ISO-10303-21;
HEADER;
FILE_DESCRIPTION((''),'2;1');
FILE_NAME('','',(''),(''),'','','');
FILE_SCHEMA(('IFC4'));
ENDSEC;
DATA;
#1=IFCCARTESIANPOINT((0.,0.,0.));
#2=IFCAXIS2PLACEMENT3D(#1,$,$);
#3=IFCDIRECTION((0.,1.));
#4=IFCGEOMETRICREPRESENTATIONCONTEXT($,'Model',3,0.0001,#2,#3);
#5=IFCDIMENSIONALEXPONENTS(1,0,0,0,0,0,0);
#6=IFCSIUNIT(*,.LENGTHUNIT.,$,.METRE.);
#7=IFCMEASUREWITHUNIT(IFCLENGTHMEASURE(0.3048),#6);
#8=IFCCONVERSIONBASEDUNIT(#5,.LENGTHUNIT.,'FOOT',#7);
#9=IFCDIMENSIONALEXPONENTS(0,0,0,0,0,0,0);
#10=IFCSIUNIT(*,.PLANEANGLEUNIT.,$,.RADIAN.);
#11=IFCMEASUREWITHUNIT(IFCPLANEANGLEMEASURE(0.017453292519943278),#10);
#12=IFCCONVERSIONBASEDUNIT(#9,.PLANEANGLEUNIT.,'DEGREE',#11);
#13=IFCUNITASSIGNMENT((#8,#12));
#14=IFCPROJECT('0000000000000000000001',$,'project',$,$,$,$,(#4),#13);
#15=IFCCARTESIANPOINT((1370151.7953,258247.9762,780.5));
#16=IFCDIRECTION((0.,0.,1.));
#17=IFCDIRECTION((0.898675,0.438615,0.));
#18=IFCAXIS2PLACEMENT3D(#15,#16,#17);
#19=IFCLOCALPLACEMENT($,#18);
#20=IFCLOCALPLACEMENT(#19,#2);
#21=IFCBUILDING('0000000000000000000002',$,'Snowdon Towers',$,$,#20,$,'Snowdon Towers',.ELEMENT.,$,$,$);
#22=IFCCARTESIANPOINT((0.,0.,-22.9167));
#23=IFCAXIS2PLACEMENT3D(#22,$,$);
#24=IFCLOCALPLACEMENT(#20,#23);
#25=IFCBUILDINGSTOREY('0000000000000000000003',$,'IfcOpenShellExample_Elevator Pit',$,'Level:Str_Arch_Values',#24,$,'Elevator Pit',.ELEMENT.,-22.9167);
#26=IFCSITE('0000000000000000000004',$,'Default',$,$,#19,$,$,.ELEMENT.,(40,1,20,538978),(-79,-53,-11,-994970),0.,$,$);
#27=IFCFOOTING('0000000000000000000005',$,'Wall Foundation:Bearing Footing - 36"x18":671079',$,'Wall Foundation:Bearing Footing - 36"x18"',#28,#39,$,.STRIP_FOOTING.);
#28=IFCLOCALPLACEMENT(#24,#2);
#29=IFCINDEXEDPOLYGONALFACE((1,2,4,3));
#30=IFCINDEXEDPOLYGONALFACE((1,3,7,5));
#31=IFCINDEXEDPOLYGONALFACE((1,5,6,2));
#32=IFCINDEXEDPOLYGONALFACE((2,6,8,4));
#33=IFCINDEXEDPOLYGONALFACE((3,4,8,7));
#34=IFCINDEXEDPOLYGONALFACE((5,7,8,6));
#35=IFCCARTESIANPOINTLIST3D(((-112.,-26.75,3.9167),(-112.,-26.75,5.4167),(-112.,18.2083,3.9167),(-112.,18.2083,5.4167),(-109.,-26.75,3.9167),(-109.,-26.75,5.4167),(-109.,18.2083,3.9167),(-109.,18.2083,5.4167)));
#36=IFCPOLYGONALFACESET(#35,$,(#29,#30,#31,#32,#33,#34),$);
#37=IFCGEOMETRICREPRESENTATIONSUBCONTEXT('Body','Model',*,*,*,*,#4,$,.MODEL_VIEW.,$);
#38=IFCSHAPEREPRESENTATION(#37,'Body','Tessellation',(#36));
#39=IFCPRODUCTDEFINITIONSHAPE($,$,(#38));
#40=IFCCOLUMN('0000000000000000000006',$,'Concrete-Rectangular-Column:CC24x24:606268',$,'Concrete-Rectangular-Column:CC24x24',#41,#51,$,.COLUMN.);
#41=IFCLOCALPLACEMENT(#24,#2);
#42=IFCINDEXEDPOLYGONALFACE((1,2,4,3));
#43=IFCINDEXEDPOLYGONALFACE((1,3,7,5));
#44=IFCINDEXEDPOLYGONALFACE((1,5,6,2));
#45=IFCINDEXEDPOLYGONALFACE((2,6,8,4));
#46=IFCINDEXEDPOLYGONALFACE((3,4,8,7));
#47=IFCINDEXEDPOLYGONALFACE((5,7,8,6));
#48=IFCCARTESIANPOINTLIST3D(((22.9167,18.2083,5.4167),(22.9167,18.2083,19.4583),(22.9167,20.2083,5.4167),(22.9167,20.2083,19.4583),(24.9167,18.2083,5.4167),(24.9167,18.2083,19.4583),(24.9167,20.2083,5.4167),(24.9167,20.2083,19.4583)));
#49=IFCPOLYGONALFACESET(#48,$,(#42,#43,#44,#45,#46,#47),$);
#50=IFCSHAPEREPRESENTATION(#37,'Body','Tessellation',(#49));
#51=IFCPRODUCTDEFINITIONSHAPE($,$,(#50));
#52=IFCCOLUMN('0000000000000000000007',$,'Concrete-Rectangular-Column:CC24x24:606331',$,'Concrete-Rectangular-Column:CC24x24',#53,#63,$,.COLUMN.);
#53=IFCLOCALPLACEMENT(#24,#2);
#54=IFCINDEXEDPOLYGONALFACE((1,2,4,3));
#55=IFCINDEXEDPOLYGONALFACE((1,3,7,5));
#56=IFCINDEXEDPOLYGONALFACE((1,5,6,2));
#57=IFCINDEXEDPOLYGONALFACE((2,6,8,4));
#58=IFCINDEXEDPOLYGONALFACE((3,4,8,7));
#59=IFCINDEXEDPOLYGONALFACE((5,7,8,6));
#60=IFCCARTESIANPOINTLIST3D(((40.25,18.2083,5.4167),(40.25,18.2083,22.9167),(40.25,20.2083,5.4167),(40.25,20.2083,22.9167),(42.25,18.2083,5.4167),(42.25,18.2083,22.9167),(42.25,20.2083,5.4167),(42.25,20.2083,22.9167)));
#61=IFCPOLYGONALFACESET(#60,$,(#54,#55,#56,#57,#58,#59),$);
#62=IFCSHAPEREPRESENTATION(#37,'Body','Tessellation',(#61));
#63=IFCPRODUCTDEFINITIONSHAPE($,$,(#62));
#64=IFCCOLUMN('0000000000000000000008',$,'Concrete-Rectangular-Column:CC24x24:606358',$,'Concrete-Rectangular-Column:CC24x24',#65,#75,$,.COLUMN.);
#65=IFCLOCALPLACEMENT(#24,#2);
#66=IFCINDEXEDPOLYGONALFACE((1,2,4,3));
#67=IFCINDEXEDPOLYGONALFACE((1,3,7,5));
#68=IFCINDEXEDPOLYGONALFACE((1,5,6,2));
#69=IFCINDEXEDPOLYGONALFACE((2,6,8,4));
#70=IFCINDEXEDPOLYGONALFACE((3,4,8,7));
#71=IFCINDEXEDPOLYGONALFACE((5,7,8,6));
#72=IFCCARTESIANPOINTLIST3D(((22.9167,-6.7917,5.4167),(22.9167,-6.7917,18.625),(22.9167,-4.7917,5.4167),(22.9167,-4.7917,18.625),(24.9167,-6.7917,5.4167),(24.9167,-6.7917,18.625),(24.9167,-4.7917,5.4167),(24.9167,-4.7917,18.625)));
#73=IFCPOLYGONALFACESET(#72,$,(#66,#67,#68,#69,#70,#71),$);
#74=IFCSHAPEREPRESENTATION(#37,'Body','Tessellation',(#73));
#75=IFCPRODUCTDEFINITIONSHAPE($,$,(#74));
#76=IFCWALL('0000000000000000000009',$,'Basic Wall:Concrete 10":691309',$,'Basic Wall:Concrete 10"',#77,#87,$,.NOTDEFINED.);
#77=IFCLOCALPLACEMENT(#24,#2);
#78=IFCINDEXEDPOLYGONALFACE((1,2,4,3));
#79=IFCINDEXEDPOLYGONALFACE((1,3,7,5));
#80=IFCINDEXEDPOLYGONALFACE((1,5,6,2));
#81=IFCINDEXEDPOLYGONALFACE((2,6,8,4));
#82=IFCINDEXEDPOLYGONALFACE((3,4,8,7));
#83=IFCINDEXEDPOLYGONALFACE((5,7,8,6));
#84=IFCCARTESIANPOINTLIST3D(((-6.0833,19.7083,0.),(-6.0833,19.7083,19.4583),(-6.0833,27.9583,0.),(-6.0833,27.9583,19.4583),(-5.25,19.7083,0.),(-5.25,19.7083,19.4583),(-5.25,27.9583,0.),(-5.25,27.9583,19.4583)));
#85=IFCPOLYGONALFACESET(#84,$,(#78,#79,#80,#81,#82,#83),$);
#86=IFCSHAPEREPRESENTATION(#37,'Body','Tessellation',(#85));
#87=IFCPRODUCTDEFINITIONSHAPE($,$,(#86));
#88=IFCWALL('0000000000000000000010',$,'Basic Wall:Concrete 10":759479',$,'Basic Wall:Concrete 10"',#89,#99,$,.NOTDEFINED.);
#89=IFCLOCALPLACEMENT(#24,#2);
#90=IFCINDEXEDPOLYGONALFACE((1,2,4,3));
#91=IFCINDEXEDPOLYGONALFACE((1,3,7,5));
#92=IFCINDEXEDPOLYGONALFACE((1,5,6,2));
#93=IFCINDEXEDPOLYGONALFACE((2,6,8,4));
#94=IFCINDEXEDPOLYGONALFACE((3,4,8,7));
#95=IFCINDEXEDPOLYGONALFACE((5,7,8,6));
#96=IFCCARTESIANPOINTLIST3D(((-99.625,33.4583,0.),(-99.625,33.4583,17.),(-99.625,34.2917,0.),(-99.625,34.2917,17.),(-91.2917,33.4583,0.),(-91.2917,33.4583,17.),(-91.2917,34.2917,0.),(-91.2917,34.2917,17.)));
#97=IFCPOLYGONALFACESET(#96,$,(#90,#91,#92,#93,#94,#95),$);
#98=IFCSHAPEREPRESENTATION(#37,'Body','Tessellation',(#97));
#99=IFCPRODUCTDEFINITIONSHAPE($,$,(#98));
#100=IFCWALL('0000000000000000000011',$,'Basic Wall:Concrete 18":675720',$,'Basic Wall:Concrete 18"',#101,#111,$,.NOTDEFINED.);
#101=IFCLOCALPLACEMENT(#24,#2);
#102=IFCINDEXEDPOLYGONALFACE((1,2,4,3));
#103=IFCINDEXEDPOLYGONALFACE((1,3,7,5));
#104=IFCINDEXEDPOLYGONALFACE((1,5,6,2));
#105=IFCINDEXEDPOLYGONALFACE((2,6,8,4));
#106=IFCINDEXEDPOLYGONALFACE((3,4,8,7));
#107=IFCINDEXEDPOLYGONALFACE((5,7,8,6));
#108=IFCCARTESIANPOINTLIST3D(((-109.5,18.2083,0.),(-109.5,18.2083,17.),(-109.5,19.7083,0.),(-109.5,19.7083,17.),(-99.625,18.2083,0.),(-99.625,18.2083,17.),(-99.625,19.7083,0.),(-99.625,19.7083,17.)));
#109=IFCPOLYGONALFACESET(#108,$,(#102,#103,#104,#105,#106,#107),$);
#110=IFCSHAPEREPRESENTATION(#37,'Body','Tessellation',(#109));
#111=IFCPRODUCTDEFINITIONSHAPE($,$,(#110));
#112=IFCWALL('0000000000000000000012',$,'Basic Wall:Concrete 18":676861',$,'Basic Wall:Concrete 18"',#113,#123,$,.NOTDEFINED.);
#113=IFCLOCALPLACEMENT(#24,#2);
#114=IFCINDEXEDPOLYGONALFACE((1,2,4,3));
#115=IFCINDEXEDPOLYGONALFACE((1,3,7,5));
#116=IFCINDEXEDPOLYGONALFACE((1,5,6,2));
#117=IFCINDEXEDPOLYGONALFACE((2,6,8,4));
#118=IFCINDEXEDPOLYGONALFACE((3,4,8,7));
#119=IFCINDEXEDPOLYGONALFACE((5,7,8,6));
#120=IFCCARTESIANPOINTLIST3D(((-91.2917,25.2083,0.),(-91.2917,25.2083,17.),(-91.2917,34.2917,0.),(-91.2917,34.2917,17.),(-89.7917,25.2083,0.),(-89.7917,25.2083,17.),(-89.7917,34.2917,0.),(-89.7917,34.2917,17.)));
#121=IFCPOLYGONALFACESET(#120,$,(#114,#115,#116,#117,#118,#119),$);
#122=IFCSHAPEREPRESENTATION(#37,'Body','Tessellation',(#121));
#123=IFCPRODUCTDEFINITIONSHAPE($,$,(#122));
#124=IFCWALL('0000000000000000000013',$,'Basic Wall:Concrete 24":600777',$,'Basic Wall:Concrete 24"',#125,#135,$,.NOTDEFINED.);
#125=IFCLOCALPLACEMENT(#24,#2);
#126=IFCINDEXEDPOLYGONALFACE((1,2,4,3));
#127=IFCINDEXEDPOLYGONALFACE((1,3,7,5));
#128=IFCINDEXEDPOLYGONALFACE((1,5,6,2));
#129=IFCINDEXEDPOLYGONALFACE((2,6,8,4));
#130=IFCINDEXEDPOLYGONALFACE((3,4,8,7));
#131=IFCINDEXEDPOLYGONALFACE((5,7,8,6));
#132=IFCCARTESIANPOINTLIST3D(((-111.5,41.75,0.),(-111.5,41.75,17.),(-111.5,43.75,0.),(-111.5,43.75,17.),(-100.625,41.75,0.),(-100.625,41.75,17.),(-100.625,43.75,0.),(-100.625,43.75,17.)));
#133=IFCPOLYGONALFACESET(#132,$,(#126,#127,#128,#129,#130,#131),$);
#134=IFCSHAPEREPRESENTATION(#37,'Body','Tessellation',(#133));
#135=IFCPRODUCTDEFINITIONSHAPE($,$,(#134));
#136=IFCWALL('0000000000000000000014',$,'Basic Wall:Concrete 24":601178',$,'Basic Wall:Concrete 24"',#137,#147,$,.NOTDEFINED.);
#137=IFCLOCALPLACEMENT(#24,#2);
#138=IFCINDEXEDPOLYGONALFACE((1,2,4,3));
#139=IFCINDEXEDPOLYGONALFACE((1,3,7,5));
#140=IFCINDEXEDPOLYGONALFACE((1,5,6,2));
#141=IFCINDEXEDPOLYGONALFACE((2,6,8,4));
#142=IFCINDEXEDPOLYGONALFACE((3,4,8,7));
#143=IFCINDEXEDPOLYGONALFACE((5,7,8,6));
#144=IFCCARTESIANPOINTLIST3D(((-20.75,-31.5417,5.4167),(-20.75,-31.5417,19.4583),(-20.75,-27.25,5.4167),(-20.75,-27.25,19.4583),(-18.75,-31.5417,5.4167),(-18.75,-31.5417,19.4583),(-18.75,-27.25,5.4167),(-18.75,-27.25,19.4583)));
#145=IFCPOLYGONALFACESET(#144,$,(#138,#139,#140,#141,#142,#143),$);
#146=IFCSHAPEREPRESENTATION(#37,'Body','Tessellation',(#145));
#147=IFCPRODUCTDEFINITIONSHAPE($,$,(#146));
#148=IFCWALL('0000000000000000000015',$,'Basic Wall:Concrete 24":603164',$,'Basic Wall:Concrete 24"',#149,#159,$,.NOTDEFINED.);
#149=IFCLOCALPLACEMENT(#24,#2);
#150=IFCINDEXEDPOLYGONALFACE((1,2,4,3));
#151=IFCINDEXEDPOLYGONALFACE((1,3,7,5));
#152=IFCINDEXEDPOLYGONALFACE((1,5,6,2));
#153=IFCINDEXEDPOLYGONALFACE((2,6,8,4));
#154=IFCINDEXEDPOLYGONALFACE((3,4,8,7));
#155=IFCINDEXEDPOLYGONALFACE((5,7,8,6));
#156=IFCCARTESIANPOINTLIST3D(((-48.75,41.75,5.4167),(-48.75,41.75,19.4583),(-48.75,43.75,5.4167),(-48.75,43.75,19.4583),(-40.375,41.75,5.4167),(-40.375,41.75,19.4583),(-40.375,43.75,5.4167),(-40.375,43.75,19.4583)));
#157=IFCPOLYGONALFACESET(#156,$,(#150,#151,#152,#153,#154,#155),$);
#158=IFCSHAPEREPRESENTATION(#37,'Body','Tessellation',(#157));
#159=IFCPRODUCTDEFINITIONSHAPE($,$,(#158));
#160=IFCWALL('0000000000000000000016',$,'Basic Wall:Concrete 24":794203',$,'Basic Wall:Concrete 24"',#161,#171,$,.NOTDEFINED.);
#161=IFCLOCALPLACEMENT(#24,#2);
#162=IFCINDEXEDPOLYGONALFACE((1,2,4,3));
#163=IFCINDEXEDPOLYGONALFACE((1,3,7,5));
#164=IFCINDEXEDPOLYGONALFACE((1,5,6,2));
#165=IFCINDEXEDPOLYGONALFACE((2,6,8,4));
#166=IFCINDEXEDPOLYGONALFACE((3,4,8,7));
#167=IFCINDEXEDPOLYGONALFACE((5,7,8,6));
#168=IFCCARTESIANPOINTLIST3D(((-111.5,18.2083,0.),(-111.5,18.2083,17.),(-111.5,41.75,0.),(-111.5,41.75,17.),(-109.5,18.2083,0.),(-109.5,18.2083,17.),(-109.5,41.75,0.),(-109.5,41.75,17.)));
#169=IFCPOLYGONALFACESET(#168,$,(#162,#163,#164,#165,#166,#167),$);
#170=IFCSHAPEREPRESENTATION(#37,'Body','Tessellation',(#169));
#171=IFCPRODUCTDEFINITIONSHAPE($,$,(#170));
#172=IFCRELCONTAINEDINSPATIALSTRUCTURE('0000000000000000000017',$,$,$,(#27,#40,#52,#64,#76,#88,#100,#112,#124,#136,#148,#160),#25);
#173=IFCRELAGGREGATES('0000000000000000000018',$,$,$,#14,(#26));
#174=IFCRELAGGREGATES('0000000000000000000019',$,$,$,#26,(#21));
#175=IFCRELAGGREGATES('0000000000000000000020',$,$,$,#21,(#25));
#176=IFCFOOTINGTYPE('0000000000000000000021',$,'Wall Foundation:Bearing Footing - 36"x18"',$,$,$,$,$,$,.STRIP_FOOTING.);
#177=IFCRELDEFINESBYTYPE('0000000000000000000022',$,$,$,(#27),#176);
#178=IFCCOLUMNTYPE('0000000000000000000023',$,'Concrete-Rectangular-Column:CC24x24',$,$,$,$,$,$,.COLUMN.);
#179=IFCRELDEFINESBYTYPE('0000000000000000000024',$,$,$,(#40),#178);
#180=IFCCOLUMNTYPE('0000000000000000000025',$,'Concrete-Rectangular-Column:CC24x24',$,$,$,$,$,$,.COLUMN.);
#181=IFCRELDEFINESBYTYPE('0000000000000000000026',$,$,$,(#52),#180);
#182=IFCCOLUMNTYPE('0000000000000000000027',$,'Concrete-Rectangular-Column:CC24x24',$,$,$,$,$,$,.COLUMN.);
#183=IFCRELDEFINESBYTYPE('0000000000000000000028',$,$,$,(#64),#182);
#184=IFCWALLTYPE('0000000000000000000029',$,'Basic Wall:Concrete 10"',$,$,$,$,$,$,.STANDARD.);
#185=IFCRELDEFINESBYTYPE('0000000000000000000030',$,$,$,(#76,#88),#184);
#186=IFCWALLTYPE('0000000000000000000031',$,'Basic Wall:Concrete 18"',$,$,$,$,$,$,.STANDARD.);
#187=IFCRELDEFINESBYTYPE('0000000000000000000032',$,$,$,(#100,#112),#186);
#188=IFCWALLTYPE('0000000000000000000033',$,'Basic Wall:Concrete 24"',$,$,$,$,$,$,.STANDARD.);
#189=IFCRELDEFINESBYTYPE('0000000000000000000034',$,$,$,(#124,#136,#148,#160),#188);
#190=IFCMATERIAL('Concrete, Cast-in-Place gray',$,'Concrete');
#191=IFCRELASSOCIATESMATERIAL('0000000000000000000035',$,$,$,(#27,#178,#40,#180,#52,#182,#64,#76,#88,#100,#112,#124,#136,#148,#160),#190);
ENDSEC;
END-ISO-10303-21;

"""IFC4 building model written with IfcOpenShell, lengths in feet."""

from ifc_helpers import new_model, entity, si_unit, converted_unit, direction, frame, origin, place, context, subcontext, project, spatial, indexed_curve, outline, extrude, source, transform, mapped, material, type_object, type_shapes, element, save


model = new_model("IFC4")

# Units and contexts
model_context = context("Model", 3, precision=0.0001, world=origin(), true_north=direction((0.0, 1.0)))
body_context = subcontext(model_context, "Body", "Model", "MODEL_VIEW")
ifc_project = project(units=[converted_unit("LENGTHUNIT", "FOOT", entity("IfcLengthMeasure", 0.3048), si_unit("LENGTHUNIT", "METRE"), dimensions=[1, 0, 0, 0, 0, 0, 0]), converted_unit("PLANEANGLEUNIT", "DEGREE", entity("IfcPlaneAngleMeasure", 0.017453292519943278), si_unit("PLANEANGLEUNIT", "RADIAN"), dimensions=[0, 0, 0, 0, 0, 0, 0])], contexts=[model_context])

# Site, building, storey
site_placement = place(None, frame((1370151.7953, 258247.9762, 780.5), z_axis=(0.0, 0.0, 1.0), x_axis=(0.898675, 0.438615, 0.0)))
site = spatial("IfcSite", under=ifc_project, at=site_placement, Name="Default", CompositionType="ELEMENT", RefLatitude=(40, 1, 20, 538978), RefLongitude=(-79, -53, -11, -994970), RefElevation=0.0)
building_placement = place(site_placement, origin())
building = spatial("IfcBuilding", under=site, at=building_placement, Name="Snowdon Towers", LongName="Snowdon Towers", CompositionType="ELEMENT")
storey_placement = place(building_placement, frame((0.0, 0.0, -22.9167)))
storey = spatial("IfcBuildingStorey", under=building, at=storey_placement, Name="IfcOpenShellExample_Elevator Pit", ObjectType="Level:Str_Arch_Values", LongName="Elevator Pit", CompositionType="ELEMENT", Elevation=-22.9167)

# Footing
ifc_material = material(Name="Concrete, Cast-in-Place gray", Category="Concrete")
footing_type = type_object("IfcFootingType", Name="Wall Foundation:Bearing Footing - 36\"x18\"", PredefinedType="STRIP_FOOTING")
footing_1_placement = place(storey_placement, origin())
element("IfcFooting", 1, at=footing_1_placement, inside=storey, type_object=footing_type, material=ifc_material, Name="Wall Foundation:Bearing Footing - 36\"x18\":671079", ObjectType="Wall Foundation:Bearing Footing - 36\"x18\"", PredefinedType="STRIP_FOOTING", context=body_context, shape_type="SweptSolid", body=[
    extrude(outline(indexed_curve([(-22.4792, -1.5), (22.4792, -1.5), (22.4792, 1.5), (-22.4792, 1.5), (-22.4792, -1.5)], self_intersect=False)), frame((-110.5, -4.2708, 3.9167), z_axis=(0.0, 0.0, 1.0), x_axis=(0.0, -1.0, 0.0)), (0.0, 0.0, 1.0), 1.5),
])

# Columns
column_type_1 = type_object("IfcColumnType", Name="Concrete-Rectangular-Column:CC24x24", PredefinedType="COLUMN", material=ifc_material)
shared_shape_1 = source(origin(), body_context, "Body", "SweptSolid", [
    extrude(outline(indexed_curve([(-1.0, -1.0), (1.0, -1.0), (1.0, 1.0), (-1.0, 1.0), (-1.0, -1.0)], self_intersect=False)), frame((23.9167, 19.2083, -17.5), z_axis=(0.0, 0.0, 1.0), x_axis=(-1.0, 0.0, 0.0)), (0.0, 0.0, 1.0), 14.0417),
])
type_shapes(column_type_1, [shared_shape_1])
column_1_placement = place(storey_placement, frame((0.0, 0.0, 22.9167)))
element("IfcColumn", 2, at=column_1_placement, inside=storey, type_object=column_type_1, material=ifc_material, Name="Concrete-Rectangular-Column:CC24x24:606268", ObjectType="Concrete-Rectangular-Column:CC24x24", PredefinedType="COLUMN", context=body_context, shape_type="MappedRepresentation", body=[
    mapped(shared_shape_1, transform((0.0, 0.0, 0.0), scale=1.0)),
])
column_type_2 = type_object("IfcColumnType", Name="Concrete-Rectangular-Column:CC24x24", PredefinedType="COLUMN", material=ifc_material)
shared_shape_2 = source(origin(), body_context, "Body", "SweptSolid", [
    extrude(outline(indexed_curve([(-1.0, -1.0), (1.0, -1.0), (1.0, 1.0), (-1.0, 1.0), (-1.0, -1.0)], self_intersect=False)), frame((41.25, 19.2083, -17.5), z_axis=(0.0, 0.0, 1.0), x_axis=(-1.0, 0.0, 0.0)), (0.0, 0.0, 1.0), 17.5),
])
type_shapes(column_type_2, [shared_shape_2])
column_2_placement = place(storey_placement, frame((0.0, 0.0, 22.9167)))
element("IfcColumn", 3, at=column_2_placement, inside=storey, type_object=column_type_2, material=ifc_material, Name="Concrete-Rectangular-Column:CC24x24:606331", ObjectType="Concrete-Rectangular-Column:CC24x24", PredefinedType="COLUMN", context=body_context, shape_type="MappedRepresentation", body=[
    mapped(shared_shape_2, transform((0.0, 0.0, 0.0), scale=1.0)),
])
column_type_3 = type_object("IfcColumnType", Name="Concrete-Rectangular-Column:CC24x24", PredefinedType="COLUMN", material=ifc_material)
shared_shape_3 = source(origin(), body_context, "Body", "SweptSolid", [
    extrude(outline(indexed_curve([(-1.0, -1.0), (1.0, -1.0), (1.0, 1.0), (-1.0, 1.0), (-1.0, -1.0)], self_intersect=False)), frame((23.9167, -5.7917, -17.5), z_axis=(0.0, 0.0, 1.0), x_axis=(-1.0, 0.0, 0.0)), (0.0, 0.0, 1.0), 13.2083),
])
type_shapes(column_type_3, [shared_shape_3])
column_3_placement = place(storey_placement, frame((0.0, 0.0, 22.9167)))
element("IfcColumn", 4, at=column_3_placement, inside=storey, type_object=column_type_3, material=ifc_material, Name="Concrete-Rectangular-Column:CC24x24:606358", ObjectType="Concrete-Rectangular-Column:CC24x24", PredefinedType="COLUMN", context=body_context, shape_type="MappedRepresentation", body=[
    mapped(shared_shape_3, transform((0.0, 0.0, 0.0), scale=1.0)),
])

# Walls
wall_type_1 = type_object("IfcWallType", Name="Basic Wall:Concrete 10\"", PredefinedType="STANDARD")
wall_1_placement = place(storey_placement, frame((-5.6667, 27.9583, 0.0), z_axis=(0.0, 0.0, 1.0), x_axis=(0.0, -1.0, 0.0)))
element("IfcWall", 5, at=wall_1_placement, inside=storey, type_object=wall_type_1, material=ifc_material, Name="Basic Wall:Concrete 10\":691309", ObjectType="Basic Wall:Concrete 10\"", PredefinedType="NOTDEFINED", context=body_context, shape_type="SweptSolid", body=[
    extrude(outline(indexed_curve([(8.25, 0.4167), (0.0, 0.4167), (0.0, -0.4167), (8.25, -0.4167), (8.25, 0.4167)], self_intersect=False)), origin(), (0.0, 0.0, 1.0), 19.4583),
])
wall_2_placement = place(storey_placement, frame((-99.625, 33.875, 0.0)))
element("IfcWall", 6, at=wall_2_placement, inside=storey, type_object=wall_type_1, material=ifc_material, Name="Basic Wall:Concrete 10\":759479", ObjectType="Basic Wall:Concrete 10\"", PredefinedType="NOTDEFINED", context=body_context, shape_type="SweptSolid", body=[
    extrude(outline(indexed_curve([(8.3333, 0.4167), (0.0, 0.4167), (0.0, -0.4167), (8.3333, -0.4167), (8.3333, 0.4167)], self_intersect=False)), origin(), (0.0, 0.0, 1.0), 17.0),
])
wall_type_2 = type_object("IfcWallType", Name="Basic Wall:Concrete 18\"", PredefinedType="STANDARD")
wall_3_placement = place(storey_placement, frame((-99.625, 18.9583, 0.0), z_axis=(0.0, 0.0, 1.0), x_axis=(-1.0, 0.0, 0.0)))
element("IfcWall", 7, at=wall_3_placement, inside=storey, type_object=wall_type_2, material=ifc_material, Name="Basic Wall:Concrete 18\":675720", ObjectType="Basic Wall:Concrete 18\"", PredefinedType="NOTDEFINED", context=body_context, shape_type="SweptSolid", body=[
    extrude(outline(indexed_curve([(9.875, 0.75), (0.0, 0.75), (0.0, -0.75), (9.875, -0.75), (9.875, 0.75)], self_intersect=False)), origin(), (0.0, 0.0, 1.0), 17.0),
])
wall_4_placement = place(storey_placement, frame((-90.5417, 34.2917, 0.0), z_axis=(0.0, 0.0, 1.0), x_axis=(0.0, -1.0, 0.0)))
element("IfcWall", 8, at=wall_4_placement, inside=storey, type_object=wall_type_2, material=ifc_material, Name="Basic Wall:Concrete 18\":676861", ObjectType="Basic Wall:Concrete 18\"", PredefinedType="NOTDEFINED", context=body_context, shape_type="SweptSolid", body=[
    extrude(outline(indexed_curve([(9.0833, 0.75), (0.0, 0.75), (0.0, -0.75), (9.0833, -0.75), (9.0833, 0.75)], self_intersect=False)), origin(), (0.0, 0.0, 1.0), 17.0),
])
wall_type_3 = type_object("IfcWallType", Name="Basic Wall:Concrete 24\"", PredefinedType="STANDARD")
wall_5_placement = place(storey_placement, frame((-111.5, 42.75, 0.0)))
element("IfcWall", 9, at=wall_5_placement, inside=storey, type_object=wall_type_3, material=ifc_material, Name="Basic Wall:Concrete 24\":600777", ObjectType="Basic Wall:Concrete 24\"", PredefinedType="NOTDEFINED", context=body_context, shape_type="SweptSolid", body=[
    extrude(outline(indexed_curve([(10.875, 1.0), (0.0, 1.0), (0.0, -1.0), (10.875, -1.0), (10.875, 1.0)], self_intersect=False)), origin(), (0.0, 0.0, 1.0), 17.0),
])
wall_6_placement = place(storey_placement, frame((-19.75, -27.25, 5.4167), z_axis=(0.0, 0.0, 1.0), x_axis=(0.0, -1.0, 0.0)))
element("IfcWall", 10, at=wall_6_placement, inside=storey, type_object=wall_type_3, material=ifc_material, Name="Basic Wall:Concrete 24\":601178", ObjectType="Basic Wall:Concrete 24\"", PredefinedType="NOTDEFINED", context=body_context, shape_type="SweptSolid", body=[
    extrude(outline(indexed_curve([(4.2917, 1.0), (0.0, 1.0), (0.0, -1.0), (4.2917, -1.0), (4.2917, 1.0)], self_intersect=False)), origin(), (0.0, 0.0, 1.0), 14.0417),
])
wall_7_placement = place(storey_placement, frame((-48.75, 42.75, 5.4167)))
element("IfcWall", 11, at=wall_7_placement, inside=storey, type_object=wall_type_3, material=ifc_material, Name="Basic Wall:Concrete 24\":603164", ObjectType="Basic Wall:Concrete 24\"", PredefinedType="NOTDEFINED", context=body_context, shape_type="SweptSolid", body=[
    extrude(outline(indexed_curve([(8.375, 1.0), (0.0, 1.0), (0.0, -1.0), (8.375, -1.0), (8.375, 1.0)], self_intersect=False)), origin(), (0.0, 0.0, 1.0), 14.0417),
])
wall_8_placement = place(storey_placement, frame((-110.5, 18.2083, 0.0), z_axis=(0.0, 0.0, 1.0), x_axis=(0.0, 1.0, 0.0)))
element("IfcWall", 12, at=wall_8_placement, inside=storey, type_object=wall_type_3, material=ifc_material, Name="Basic Wall:Concrete 24\":794203", ObjectType="Basic Wall:Concrete 24\"", PredefinedType="NOTDEFINED", context=body_context, shape_type="SweptSolid", body=[
    extrude(outline(indexed_curve([(23.5417, 1.0), (0.0, 1.0), (0.0, -1.0), (23.5417, -1.0), (23.5417, 1.0)], self_intersect=False)), origin(), (0.0, 0.0, 1.0), 17.0),
])

save(model, "model.ifc")
